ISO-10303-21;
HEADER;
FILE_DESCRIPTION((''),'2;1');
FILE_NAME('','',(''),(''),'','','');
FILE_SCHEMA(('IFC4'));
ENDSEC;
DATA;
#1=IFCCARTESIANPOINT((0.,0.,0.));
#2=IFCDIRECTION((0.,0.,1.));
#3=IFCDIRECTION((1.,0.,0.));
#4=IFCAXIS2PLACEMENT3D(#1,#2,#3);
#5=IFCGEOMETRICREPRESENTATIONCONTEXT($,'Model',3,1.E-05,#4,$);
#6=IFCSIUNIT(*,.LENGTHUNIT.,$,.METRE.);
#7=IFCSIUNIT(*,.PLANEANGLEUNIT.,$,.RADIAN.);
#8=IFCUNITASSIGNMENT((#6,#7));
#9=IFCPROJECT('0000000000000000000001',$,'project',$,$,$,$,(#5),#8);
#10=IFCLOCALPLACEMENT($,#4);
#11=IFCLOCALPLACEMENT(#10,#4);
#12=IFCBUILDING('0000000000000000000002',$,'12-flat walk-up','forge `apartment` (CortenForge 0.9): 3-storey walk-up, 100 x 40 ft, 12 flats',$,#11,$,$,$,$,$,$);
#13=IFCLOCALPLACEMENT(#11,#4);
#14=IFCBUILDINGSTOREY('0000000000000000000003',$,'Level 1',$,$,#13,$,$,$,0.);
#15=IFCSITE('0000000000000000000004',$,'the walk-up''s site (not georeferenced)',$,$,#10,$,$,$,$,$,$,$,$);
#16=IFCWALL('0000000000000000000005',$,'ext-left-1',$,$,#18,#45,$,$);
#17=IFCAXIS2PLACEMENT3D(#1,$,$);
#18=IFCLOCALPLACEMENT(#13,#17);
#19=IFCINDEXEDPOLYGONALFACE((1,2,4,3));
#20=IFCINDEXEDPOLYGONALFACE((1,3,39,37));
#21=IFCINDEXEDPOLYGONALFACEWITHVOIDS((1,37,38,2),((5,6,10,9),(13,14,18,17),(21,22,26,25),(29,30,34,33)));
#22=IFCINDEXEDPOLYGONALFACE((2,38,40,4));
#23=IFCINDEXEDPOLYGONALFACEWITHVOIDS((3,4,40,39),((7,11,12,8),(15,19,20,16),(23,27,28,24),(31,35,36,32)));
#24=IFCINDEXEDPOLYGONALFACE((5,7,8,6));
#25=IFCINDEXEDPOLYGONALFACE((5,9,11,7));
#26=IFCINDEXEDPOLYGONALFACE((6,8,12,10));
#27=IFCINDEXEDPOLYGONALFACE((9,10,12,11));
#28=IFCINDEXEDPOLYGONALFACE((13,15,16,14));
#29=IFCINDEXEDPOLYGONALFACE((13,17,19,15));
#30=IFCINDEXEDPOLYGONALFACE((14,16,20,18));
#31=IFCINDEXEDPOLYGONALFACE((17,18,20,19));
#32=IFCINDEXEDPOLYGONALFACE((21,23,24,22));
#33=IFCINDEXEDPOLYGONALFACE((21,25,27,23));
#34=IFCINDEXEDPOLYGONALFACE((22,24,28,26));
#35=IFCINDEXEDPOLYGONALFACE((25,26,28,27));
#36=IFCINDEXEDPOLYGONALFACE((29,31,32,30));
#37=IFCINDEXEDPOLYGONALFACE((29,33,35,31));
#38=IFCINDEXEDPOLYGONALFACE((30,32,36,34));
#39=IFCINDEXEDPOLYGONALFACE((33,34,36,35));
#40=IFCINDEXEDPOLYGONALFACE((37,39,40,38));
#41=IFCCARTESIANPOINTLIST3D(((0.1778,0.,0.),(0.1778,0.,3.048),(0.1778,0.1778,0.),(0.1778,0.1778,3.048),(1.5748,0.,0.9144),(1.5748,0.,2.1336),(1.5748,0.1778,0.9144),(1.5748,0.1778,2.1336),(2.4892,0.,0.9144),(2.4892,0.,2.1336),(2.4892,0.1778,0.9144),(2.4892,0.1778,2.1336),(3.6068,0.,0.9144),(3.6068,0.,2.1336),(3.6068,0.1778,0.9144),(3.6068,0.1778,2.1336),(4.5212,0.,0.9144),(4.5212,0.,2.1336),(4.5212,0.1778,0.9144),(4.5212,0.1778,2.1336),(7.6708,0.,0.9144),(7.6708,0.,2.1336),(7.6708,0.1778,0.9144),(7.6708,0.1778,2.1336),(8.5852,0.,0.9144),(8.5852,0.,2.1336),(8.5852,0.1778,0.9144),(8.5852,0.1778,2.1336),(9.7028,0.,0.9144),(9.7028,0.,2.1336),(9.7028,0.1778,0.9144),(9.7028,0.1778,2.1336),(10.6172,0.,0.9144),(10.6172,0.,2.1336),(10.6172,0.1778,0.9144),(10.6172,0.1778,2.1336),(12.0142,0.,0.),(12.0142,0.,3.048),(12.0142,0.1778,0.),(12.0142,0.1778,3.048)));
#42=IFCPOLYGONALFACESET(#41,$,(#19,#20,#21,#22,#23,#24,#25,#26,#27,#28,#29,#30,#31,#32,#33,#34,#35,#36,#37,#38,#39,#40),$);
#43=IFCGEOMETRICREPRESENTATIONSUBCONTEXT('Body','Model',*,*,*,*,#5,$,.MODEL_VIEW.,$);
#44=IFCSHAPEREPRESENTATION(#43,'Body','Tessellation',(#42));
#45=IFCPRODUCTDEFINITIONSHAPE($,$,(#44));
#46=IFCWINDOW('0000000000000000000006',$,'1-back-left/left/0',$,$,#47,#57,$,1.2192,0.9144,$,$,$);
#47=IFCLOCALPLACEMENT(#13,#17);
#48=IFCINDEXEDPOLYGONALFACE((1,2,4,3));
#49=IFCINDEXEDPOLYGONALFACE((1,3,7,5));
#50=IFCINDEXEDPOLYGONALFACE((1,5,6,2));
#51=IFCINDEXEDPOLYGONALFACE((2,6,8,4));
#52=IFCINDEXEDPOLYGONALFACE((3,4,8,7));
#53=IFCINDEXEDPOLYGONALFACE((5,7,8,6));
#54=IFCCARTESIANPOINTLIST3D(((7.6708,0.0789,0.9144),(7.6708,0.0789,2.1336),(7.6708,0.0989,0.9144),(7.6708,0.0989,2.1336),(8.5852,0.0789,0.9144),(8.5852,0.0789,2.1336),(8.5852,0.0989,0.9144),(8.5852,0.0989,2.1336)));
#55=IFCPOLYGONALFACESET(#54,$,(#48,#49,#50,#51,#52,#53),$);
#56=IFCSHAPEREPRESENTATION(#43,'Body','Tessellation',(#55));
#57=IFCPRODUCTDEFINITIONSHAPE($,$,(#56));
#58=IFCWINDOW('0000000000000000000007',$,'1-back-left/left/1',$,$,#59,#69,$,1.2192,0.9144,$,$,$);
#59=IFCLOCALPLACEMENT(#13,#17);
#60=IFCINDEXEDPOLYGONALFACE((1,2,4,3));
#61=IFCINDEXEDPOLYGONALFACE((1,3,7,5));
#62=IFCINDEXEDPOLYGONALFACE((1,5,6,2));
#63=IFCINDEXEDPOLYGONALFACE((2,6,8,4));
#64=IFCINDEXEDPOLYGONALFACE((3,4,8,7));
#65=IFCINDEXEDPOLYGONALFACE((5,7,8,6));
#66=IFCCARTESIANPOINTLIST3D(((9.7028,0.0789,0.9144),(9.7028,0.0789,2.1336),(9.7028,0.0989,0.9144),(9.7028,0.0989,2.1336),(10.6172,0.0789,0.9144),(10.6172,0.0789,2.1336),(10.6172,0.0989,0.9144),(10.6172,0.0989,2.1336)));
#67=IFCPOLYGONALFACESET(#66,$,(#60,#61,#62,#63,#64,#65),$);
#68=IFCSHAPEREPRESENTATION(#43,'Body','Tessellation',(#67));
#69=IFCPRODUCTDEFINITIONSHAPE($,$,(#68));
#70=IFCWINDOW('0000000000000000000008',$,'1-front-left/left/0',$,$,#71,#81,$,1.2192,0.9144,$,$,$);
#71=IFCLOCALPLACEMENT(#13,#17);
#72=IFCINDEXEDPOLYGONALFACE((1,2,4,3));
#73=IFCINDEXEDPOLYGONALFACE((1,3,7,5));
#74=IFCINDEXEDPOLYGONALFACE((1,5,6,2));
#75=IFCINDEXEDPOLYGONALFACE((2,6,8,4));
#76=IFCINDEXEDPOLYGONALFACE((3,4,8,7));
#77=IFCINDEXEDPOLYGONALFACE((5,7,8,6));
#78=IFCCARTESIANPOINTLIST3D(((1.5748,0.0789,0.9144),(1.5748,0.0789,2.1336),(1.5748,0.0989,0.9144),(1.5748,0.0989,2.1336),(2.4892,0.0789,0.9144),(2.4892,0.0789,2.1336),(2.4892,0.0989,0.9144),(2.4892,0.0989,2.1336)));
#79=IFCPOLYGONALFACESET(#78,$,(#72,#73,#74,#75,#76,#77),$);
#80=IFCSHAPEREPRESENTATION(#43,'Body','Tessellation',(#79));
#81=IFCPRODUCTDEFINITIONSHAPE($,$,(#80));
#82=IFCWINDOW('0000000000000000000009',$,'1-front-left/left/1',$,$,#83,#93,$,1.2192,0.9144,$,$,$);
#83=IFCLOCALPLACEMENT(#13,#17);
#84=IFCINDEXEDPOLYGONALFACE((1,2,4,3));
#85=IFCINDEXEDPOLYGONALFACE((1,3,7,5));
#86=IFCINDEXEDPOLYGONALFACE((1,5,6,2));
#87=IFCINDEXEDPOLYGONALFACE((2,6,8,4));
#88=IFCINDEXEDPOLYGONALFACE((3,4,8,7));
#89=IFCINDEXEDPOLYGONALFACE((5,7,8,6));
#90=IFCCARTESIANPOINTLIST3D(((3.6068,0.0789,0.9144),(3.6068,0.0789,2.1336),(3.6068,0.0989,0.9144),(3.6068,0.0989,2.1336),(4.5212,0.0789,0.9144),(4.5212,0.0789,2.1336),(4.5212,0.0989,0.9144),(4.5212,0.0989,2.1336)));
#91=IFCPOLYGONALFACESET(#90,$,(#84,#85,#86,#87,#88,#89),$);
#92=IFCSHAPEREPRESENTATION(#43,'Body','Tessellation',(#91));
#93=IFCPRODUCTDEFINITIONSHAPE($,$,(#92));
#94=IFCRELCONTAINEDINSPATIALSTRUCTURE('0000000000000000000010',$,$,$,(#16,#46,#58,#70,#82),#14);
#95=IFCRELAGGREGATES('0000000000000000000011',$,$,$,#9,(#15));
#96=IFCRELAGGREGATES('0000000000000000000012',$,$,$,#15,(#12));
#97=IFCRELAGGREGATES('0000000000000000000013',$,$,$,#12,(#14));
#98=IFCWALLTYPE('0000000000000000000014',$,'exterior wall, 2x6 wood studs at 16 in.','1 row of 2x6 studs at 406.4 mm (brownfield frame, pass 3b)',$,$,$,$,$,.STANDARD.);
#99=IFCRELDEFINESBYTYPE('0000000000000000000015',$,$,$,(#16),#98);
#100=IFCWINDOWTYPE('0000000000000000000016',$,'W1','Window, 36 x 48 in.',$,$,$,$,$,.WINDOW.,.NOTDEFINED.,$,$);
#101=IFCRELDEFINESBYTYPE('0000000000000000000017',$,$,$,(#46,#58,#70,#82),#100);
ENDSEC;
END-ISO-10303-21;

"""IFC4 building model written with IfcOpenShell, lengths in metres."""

from ifc_helpers import new_model, si_unit, frame, frame_2d, origin, origin_with_axes, place, context, subcontext, project, spatial, rectangle, extrude, type_object, element, fill, save


model = new_model("IFC4")

# Units and contexts
model_context = context("Model", 3, precision=1e-05, world=origin_with_axes())
body_context = subcontext(model_context, "Body", "Model", "MODEL_VIEW")
ifc_project = project(units=[si_unit("LENGTHUNIT", "METRE"), si_unit("PLANEANGLEUNIT", "RADIAN")], contexts=[model_context])

# Site, building, storey
site_placement = place(None, origin_with_axes())
site = spatial("IfcSite", under=ifc_project, at=site_placement, Name="the walk-up's site (not georeferenced)")
building_placement = place(site_placement, origin_with_axes())
building = spatial("IfcBuilding", under=site, at=building_placement, Name="12-flat walk-up", Description="forge `apartment` (CortenForge 0.9): 3-storey walk-up, 100 x 40 ft, 12 flats")
storey_placement = place(building_placement, origin_with_axes())
storey = spatial("IfcBuildingStorey", under=building, at=storey_placement, Name="Level 1", Elevation=0.0)

# Shared definitions
wall_type = type_object("IfcWallType", Name="exterior wall, 2x6 wood studs at 16 in.", Description="1 row of 2x6 studs at 406.4 mm (brownfield frame, pass 3b)", PredefinedType="STANDARD")
window_type_1 = type_object("IfcWindowType", Name="W1", Description="Window, 36 x 48 in.", PartitioningType="NOTDEFINED", PredefinedType="WINDOW")

# Wall, openings, windows
wall_1_placement = place(storey_placement, frame((0.1778, 0.0, 0.0), z_axis=(0.0, 0.0, 1.0), x_axis=(1.0, 0.0, 0.0)))
wall_1 = element("IfcWall", 1, at=wall_1_placement, inside=storey, type_object=wall_type, Name="ext-left-1", context=body_context, shape_type="SweptSolid", body=[
    extrude(rectangle(XDim=11.8364, YDim=0.1778, at=frame_2d((5.9182, 0.0889))), origin(), (0.0, 0.0, 1.0), 3.048),
])
opening_1_placement = place(wall_1_placement, frame((7.493, 0.0, 0.9144), z_axis=(0.0, 0.0, 1.0), x_axis=(1.0, 0.0, 0.0)))
opening_1 = element("IfcOpeningElement", 2, at=opening_1_placement, cuts=wall_1, PredefinedType="OPENING", context=body_context, shape_type="SweptSolid", body=[
    extrude(rectangle(XDim=0.9144, YDim=0.1778, at=frame_2d((0.4572, 0.0889))), origin(), (0.0, 0.0, 1.0), 1.2192),
])
opening_2_placement = place(wall_1_placement, frame((9.525, 0.0, 0.9144), z_axis=(0.0, 0.0, 1.0), x_axis=(1.0, 0.0, 0.0)))
opening_2 = element("IfcOpeningElement", 3, at=opening_2_placement, cuts=wall_1, PredefinedType="OPENING", context=body_context, shape_type="SweptSolid", body=[
    extrude(rectangle(XDim=0.9144, YDim=0.1778, at=frame_2d((0.4572, 0.0889))), origin(), (0.0, 0.0, 1.0), 1.2192),
])
opening_3_placement = place(wall_1_placement, frame((1.397, 0.0, 0.9144), z_axis=(0.0, 0.0, 1.0), x_axis=(1.0, 0.0, 0.0)))
opening_3 = element("IfcOpeningElement", 4, at=opening_3_placement, cuts=wall_1, PredefinedType="OPENING", context=body_context, shape_type="SweptSolid", body=[
    extrude(rectangle(XDim=0.9144, YDim=0.1778, at=frame_2d((0.4572, 0.0889))), origin(), (0.0, 0.0, 1.0), 1.2192),
])
opening_4_placement = place(wall_1_placement, frame((3.429, 0.0, 0.9144), z_axis=(0.0, 0.0, 1.0), x_axis=(1.0, 0.0, 0.0)))
opening_4 = element("IfcOpeningElement", 5, at=opening_4_placement, cuts=wall_1, PredefinedType="OPENING", context=body_context, shape_type="SweptSolid", body=[
    extrude(rectangle(XDim=0.9144, YDim=0.1778, at=frame_2d((0.4572, 0.0889))), origin(), (0.0, 0.0, 1.0), 1.2192),
])
window_1_placement = place(opening_1_placement, frame((0.0, 0.0789, 0.0), z_axis=(0.0, 0.0, 1.0), x_axis=(1.0, 0.0, 0.0)))
window_1 = element("IfcWindow", 6, at=window_1_placement, inside=storey, type_object=window_type_1, Name="1-back-left/left/0", OverallHeight=1.2192, OverallWidth=0.9144, context=body_context, shape_type="SweptSolid", body=[
    extrude(rectangle(XDim=0.9144, YDim=0.02, at=frame_2d((0.4572, 0.01))), origin(), (0.0, 0.0, 1.0), 1.2192),
])
fill(opening_1, window_1)
window_2_placement = place(opening_2_placement, frame((0.0, 0.0789, 0.0), z_axis=(0.0, 0.0, 1.0), x_axis=(1.0, 0.0, 0.0)))
window_2 = element("IfcWindow", 7, at=window_2_placement, inside=storey, type_object=window_type_1, Name="1-back-left/left/1", OverallHeight=1.2192, OverallWidth=0.9144, context=body_context, shape_type="SweptSolid", body=[
    extrude(rectangle(XDim=0.9144, YDim=0.02, at=frame_2d((0.4572, 0.01))), origin(), (0.0, 0.0, 1.0), 1.2192),
])
fill(opening_2, window_2)
window_3_placement = place(opening_3_placement, frame((0.0, 0.0789, 0.0), z_axis=(0.0, 0.0, 1.0), x_axis=(1.0, 0.0, 0.0)))
window_3 = element("IfcWindow", 8, at=window_3_placement, inside=storey, type_object=window_type_1, Name="1-front-left/left/0", OverallHeight=1.2192, OverallWidth=0.9144, context=body_context, shape_type="SweptSolid", body=[
    extrude(rectangle(XDim=0.9144, YDim=0.02, at=frame_2d((0.4572, 0.01))), origin(), (0.0, 0.0, 1.0), 1.2192),
])
fill(opening_3, window_3)
window_4_placement = place(opening_4_placement, frame((0.0, 0.0789, 0.0), z_axis=(0.0, 0.0, 1.0), x_axis=(1.0, 0.0, 0.0)))
window_4 = element("IfcWindow", 9, at=window_4_placement, inside=storey, type_object=window_type_1, Name="1-front-left/left/1", OverallHeight=1.2192, OverallWidth=0.9144, context=body_context, shape_type="SweptSolid", body=[
    extrude(rectangle(XDim=0.9144, YDim=0.02, at=frame_2d((0.4572, 0.01))), origin(), (0.0, 0.0, 1.0), 1.2192),
])
fill(opening_4, window_4)

save(model, "model.ifc")
